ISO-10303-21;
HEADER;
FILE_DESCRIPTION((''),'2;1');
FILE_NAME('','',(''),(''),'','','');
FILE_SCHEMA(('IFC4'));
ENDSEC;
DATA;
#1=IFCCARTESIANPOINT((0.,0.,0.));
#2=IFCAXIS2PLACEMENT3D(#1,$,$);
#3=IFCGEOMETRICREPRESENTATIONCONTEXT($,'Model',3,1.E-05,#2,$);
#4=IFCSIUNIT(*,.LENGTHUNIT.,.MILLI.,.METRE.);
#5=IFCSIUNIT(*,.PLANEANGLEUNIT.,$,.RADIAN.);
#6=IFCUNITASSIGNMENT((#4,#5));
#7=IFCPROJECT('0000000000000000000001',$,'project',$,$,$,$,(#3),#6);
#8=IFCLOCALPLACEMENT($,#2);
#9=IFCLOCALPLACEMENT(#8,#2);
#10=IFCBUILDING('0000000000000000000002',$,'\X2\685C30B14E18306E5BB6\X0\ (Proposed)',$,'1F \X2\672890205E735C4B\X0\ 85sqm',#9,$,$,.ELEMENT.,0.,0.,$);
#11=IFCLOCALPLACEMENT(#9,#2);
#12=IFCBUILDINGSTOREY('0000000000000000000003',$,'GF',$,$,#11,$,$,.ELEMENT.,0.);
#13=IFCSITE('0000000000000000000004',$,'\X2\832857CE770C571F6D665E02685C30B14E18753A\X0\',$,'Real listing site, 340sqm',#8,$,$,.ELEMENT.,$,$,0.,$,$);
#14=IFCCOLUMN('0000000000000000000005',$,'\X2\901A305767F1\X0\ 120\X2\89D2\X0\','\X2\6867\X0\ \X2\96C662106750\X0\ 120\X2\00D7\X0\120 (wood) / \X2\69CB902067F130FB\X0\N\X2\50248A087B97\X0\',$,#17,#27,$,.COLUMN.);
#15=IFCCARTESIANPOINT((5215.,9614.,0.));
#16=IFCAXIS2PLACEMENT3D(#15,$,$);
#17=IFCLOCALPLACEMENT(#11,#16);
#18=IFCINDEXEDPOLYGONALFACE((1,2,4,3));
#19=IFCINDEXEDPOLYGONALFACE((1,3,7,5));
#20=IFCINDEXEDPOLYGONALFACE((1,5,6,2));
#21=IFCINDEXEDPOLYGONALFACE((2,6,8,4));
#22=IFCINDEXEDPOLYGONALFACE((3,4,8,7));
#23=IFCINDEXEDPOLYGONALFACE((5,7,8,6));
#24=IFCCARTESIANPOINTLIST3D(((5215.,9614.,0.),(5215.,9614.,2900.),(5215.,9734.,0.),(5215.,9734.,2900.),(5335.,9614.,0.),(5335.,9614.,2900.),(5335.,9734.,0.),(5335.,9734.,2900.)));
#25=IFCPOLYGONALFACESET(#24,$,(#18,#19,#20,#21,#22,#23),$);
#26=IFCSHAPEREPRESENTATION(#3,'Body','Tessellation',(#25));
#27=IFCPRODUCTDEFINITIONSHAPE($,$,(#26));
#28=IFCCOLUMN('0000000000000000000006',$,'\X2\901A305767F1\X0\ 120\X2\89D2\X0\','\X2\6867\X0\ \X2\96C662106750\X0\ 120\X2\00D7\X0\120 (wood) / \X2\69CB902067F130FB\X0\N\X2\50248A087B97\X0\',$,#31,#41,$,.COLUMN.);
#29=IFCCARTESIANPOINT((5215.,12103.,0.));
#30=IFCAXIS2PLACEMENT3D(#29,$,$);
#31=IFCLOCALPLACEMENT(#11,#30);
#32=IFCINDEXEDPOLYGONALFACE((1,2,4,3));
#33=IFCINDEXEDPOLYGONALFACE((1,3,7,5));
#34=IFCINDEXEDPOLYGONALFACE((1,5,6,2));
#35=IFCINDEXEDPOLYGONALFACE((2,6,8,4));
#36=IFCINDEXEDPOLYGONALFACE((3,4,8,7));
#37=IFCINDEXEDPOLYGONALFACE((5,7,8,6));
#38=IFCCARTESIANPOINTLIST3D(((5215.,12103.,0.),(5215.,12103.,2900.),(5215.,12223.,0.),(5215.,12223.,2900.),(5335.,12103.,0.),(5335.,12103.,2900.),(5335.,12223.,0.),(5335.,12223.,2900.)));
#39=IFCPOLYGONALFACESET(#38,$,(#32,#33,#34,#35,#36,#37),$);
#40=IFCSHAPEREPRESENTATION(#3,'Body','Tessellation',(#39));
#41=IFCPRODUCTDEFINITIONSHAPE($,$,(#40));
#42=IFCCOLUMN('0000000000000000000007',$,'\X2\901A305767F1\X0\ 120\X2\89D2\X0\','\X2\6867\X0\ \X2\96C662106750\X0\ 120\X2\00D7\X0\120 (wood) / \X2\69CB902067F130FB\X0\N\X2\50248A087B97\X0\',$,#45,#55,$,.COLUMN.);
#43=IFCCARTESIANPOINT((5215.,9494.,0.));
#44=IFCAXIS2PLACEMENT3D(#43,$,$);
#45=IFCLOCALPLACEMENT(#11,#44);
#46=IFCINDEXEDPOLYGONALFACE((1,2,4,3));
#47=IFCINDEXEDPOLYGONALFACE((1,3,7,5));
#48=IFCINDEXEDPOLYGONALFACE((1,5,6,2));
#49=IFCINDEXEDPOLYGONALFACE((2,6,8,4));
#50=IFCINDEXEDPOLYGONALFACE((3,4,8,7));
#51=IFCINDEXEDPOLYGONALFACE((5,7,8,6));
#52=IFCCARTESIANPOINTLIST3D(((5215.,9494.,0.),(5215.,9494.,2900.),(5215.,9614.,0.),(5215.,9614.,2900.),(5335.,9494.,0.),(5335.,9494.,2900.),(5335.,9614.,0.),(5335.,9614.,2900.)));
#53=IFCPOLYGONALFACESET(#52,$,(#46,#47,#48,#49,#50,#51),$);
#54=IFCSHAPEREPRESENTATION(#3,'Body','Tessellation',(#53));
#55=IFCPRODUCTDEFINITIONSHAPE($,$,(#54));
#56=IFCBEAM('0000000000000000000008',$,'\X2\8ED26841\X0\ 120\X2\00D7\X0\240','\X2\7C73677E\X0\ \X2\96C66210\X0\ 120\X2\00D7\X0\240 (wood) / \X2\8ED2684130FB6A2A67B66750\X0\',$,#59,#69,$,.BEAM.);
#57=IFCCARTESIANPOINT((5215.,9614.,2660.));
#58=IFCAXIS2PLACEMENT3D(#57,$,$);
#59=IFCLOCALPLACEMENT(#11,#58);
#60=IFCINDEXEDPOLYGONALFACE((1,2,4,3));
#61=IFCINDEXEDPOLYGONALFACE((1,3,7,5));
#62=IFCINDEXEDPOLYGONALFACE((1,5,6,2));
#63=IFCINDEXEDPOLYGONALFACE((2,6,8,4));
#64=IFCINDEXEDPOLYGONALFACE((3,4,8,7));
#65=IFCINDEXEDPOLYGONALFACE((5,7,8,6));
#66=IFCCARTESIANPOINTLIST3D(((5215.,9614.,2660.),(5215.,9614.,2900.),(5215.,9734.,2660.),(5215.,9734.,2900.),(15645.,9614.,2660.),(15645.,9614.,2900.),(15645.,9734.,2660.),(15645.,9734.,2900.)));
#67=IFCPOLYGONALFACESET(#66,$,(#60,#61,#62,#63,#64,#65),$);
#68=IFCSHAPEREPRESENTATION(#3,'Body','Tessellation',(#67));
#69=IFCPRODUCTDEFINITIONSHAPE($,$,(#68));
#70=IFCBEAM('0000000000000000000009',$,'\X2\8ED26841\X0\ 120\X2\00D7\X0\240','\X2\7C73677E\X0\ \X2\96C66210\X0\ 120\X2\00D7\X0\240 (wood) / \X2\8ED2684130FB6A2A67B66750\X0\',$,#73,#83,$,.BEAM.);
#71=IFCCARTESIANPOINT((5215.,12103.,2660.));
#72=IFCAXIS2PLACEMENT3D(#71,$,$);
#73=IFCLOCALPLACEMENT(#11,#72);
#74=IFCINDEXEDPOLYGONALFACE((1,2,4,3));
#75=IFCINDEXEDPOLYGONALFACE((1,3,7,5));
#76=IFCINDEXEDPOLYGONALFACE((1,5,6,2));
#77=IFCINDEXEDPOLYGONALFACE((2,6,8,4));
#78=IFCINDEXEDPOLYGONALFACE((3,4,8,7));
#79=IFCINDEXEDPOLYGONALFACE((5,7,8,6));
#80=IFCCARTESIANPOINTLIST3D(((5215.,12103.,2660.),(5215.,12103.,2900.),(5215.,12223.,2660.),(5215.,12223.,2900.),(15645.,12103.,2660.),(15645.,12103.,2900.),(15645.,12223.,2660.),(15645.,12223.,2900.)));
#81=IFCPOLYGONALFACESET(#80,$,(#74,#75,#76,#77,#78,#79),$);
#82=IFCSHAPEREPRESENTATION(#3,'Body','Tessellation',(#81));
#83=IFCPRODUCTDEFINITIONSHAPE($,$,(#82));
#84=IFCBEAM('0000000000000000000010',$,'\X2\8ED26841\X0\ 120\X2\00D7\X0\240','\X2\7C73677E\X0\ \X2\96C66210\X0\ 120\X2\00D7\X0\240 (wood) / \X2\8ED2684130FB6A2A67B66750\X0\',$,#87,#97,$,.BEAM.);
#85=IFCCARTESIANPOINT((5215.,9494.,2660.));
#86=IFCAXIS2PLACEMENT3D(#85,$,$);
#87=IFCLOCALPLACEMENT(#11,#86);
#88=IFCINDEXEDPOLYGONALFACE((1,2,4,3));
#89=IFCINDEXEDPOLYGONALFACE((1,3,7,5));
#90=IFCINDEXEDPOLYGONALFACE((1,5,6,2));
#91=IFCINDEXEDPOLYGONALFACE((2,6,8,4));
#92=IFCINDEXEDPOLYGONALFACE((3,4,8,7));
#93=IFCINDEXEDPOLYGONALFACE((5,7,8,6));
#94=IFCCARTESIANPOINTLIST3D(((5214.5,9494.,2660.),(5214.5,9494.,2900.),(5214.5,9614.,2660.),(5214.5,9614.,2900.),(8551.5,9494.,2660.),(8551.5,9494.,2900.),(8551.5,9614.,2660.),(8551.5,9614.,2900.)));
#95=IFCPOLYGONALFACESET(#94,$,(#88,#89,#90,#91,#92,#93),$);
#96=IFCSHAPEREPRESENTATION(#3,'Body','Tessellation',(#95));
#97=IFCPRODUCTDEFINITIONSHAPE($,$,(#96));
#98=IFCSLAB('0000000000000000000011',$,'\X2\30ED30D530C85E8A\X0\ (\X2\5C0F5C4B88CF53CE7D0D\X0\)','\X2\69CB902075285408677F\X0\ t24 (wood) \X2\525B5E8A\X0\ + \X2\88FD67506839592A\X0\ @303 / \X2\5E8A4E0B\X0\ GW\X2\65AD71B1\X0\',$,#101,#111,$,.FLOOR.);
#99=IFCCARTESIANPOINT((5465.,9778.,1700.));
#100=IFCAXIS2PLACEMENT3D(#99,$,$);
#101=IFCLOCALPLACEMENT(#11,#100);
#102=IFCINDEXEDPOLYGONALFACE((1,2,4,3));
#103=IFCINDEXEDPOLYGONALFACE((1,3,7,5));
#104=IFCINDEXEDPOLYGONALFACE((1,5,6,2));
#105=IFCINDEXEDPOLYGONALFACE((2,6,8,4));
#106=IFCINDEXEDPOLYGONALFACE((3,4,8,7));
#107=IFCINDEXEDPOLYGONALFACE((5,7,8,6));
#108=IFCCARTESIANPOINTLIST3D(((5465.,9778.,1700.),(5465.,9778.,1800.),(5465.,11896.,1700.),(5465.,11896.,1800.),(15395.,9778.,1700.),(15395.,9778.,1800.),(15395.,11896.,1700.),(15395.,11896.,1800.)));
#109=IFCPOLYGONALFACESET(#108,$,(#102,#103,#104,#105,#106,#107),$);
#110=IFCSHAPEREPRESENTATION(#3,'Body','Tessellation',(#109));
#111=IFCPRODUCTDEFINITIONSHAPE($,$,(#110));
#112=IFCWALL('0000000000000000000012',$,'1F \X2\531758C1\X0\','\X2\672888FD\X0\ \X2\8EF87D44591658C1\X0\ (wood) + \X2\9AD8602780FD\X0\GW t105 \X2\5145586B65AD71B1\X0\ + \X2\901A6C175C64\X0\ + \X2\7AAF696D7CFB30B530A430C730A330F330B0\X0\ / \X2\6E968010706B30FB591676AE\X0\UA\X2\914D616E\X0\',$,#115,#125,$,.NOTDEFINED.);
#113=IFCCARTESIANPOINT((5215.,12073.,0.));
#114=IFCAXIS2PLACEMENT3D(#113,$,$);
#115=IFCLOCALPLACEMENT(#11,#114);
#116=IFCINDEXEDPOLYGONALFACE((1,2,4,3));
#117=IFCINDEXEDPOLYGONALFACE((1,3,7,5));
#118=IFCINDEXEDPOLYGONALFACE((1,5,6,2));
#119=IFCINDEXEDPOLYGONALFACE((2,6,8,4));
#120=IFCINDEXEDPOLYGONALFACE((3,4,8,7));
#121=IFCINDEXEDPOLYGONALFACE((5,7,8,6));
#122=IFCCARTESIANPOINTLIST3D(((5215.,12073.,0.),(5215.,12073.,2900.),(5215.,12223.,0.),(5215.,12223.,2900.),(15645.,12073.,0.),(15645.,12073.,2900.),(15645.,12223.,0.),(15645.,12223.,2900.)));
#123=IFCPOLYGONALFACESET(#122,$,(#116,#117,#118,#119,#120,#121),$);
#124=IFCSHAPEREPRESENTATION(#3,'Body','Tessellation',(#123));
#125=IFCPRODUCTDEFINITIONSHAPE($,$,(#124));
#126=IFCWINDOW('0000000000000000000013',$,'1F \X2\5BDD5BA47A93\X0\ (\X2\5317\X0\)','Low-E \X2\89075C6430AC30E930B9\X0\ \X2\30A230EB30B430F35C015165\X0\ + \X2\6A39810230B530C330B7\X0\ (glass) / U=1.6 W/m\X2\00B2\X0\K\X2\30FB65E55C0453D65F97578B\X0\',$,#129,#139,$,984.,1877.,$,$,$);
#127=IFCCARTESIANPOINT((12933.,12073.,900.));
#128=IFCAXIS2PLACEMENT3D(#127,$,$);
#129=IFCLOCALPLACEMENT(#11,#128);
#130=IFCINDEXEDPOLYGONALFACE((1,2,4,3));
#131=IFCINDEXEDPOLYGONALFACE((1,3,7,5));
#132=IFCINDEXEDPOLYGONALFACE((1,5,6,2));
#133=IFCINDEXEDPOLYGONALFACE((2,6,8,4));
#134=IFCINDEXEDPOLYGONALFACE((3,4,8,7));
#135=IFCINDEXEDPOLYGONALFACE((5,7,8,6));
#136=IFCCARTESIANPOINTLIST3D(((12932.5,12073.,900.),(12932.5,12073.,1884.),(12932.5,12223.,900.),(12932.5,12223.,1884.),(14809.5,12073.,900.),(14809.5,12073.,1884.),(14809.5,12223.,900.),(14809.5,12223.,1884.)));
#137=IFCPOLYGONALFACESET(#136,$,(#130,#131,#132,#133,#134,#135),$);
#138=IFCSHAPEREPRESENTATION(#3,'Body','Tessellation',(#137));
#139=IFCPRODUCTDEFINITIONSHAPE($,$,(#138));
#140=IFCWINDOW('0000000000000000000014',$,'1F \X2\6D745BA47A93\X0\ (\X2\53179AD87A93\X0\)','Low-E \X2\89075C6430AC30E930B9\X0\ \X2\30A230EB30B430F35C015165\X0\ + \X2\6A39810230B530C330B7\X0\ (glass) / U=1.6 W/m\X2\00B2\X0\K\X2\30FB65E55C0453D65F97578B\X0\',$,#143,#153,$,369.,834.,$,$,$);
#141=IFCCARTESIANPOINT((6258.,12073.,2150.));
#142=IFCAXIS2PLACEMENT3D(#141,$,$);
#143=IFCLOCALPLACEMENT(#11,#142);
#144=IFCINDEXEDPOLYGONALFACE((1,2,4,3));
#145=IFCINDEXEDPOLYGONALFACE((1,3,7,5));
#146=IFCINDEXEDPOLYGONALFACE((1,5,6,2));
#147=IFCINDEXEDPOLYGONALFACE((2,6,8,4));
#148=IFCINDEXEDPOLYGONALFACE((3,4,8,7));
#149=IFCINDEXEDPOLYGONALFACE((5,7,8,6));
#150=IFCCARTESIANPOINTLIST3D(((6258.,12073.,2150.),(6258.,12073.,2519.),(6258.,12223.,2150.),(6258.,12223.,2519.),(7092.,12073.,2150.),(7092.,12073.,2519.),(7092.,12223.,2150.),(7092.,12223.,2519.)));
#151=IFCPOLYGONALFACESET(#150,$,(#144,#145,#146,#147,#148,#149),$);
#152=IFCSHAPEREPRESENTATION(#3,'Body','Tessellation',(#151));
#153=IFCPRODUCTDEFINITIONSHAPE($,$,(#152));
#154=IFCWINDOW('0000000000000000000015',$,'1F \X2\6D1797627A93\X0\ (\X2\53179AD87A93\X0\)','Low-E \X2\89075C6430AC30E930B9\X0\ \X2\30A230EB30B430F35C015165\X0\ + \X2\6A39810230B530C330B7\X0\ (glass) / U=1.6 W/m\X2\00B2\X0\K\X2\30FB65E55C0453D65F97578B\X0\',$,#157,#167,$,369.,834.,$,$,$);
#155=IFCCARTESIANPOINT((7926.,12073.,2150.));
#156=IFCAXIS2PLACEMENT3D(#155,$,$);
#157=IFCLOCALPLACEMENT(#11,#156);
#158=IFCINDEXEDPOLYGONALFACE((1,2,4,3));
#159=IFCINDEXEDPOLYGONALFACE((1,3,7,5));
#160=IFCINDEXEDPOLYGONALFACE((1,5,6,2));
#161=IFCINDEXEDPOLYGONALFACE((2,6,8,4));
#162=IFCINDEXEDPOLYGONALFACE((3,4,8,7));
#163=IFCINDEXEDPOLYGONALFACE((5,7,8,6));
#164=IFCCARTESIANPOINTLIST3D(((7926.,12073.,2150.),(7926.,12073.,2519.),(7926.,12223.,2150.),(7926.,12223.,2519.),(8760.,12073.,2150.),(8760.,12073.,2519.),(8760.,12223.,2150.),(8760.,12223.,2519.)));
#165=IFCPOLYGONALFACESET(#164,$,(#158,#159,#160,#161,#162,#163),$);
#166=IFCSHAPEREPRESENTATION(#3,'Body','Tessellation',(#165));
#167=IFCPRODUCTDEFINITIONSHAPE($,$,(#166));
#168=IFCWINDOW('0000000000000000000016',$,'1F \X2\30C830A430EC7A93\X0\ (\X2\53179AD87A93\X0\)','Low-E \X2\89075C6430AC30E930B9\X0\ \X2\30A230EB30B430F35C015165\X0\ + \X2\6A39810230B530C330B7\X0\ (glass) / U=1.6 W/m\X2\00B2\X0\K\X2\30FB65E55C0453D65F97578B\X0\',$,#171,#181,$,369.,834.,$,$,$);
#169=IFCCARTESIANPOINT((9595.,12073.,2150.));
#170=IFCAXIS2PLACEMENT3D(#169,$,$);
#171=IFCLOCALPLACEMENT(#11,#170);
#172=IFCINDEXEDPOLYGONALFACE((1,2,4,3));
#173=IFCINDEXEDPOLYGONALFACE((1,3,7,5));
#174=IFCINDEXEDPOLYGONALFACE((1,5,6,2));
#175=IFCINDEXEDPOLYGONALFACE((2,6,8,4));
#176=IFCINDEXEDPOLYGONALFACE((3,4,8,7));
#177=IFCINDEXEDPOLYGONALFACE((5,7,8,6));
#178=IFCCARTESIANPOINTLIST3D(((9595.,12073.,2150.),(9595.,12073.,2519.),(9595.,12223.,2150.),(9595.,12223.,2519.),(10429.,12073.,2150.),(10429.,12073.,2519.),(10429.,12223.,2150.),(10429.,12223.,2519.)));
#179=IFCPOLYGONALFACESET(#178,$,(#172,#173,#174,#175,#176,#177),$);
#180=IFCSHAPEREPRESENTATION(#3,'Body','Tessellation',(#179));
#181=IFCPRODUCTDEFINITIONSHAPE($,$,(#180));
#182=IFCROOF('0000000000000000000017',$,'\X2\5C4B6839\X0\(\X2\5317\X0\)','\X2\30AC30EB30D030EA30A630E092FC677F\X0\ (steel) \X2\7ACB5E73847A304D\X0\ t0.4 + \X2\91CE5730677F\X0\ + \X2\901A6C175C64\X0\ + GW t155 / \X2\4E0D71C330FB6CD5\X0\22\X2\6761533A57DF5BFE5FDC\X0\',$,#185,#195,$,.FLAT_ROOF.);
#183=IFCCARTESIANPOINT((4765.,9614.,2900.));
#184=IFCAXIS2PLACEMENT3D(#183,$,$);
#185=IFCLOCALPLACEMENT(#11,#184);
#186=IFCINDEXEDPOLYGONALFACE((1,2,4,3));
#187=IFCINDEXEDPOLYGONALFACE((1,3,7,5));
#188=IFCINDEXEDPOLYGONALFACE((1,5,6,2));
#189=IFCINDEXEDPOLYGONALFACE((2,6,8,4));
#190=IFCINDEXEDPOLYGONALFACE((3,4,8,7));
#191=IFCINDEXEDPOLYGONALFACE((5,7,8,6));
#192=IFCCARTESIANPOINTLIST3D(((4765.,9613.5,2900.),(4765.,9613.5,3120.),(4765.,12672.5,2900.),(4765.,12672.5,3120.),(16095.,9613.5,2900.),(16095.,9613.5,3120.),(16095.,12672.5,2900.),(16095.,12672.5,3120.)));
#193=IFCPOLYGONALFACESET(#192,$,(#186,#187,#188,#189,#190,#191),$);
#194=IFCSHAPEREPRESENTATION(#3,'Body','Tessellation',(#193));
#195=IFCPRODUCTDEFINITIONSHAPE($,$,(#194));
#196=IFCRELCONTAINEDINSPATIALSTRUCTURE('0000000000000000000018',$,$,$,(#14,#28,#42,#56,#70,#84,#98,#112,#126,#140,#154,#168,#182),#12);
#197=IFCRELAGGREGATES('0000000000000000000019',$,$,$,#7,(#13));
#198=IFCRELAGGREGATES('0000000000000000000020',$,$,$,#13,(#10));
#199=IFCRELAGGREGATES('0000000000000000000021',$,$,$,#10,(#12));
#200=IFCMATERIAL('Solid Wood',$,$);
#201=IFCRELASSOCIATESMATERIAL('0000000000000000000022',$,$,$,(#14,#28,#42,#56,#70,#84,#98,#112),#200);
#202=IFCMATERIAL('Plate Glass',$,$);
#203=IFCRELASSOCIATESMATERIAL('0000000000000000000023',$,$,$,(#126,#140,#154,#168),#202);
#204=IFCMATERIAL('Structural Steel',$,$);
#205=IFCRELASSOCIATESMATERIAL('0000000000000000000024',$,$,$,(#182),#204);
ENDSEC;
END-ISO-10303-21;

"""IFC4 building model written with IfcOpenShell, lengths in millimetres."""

from ifc_helpers import new_model, si_unit, frame, frame_2d, origin, place, context, project, spatial, rectangle, extrude, material, element, fill, save


model = new_model("IFC4")

# Units and contexts
model_context = context("Model", 3, precision=1e-05, world=origin())
ifc_project = project(units=[si_unit("LENGTHUNIT", "METRE", prefix="MILLI"), si_unit("PLANEANGLEUNIT", "RADIAN")], contexts=[model_context])

# Site, building, storey
site_placement = place(None, origin())
site = spatial("IfcSite", under=ifc_project, at=site_placement, Name="茨城県土浦市桜ケ丘町", ObjectType="Real listing site, 340sqm", CompositionType="ELEMENT", RefElevation=0.0)
building_placement = place(site_placement, origin())
building = spatial("IfcBuilding", under=site, at=building_placement, Name="桜ケ丘の家 (Proposed)", ObjectType="1F 木造平屋 85sqm", CompositionType="ELEMENT", ElevationOfRefHeight=0.0, ElevationOfTerrain=0.0)
storey_placement = place(building_placement, origin())
storey = spatial("IfcBuildingStorey", under=building, at=storey_placement, Name="GF", CompositionType="ELEMENT", Elevation=0.0)

# Columns
ifc_material_1 = material(Name="Solid Wood")
column_1_placement = place(storey_placement, frame((5215.0, 9614.0, 0.0)))
element("IfcColumn", 1, at=column_1_placement, inside=storey, material=ifc_material_1, Name="通し柱 120角", Description="桧 集成材 120×120 (wood) / 構造柱・N値計算", PredefinedType="COLUMN", context=model_context, shape_type="SweptSolid", body=[
    extrude(rectangle(XDim=120.0, YDim=120.0, at=frame_2d((60.0, 60.0))), frame((5215.0, 9614.0, 0.0)), (0.0, 0.0, 1.0), 2900.0),
])
column_2_placement = place(storey_placement, frame((5215.0, 12103.0, 0.0)))
element("IfcColumn", 2, at=column_2_placement, inside=storey, material=ifc_material_1, Name="通し柱 120角", Description="桧 集成材 120×120 (wood) / 構造柱・N値計算", PredefinedType="COLUMN", context=model_context, shape_type="SweptSolid", body=[
    extrude(rectangle(XDim=120.0, YDim=120.0, at=frame_2d((60.0, 60.0))), frame((5215.0, 12103.0, 0.0)), (0.0, 0.0, 1.0), 2900.0),
])
column_3_placement = place(storey_placement, frame((5215.0, 9494.0, 0.0)))
element("IfcColumn", 3, at=column_3_placement, inside=storey, material=ifc_material_1, Name="通し柱 120角", Description="桧 集成材 120×120 (wood) / 構造柱・N値計算", PredefinedType="COLUMN", context=model_context, shape_type="SweptSolid", body=[
    extrude(rectangle(XDim=120.0, YDim=120.0, at=frame_2d((60.0, 60.0))), frame((5215.0, 9494.0, 0.0)), (0.0, 0.0, 1.0), 2900.0),
])

# Beams
beam_1_placement = place(storey_placement, frame((5215.0, 9614.0, 2660.0)))
element("IfcBeam", 4, at=beam_1_placement, inside=storey, material=ifc_material_1, Name="軒桁 120×240", Description="米松 集成 120×240 (wood) / 軒桁・横架材", PredefinedType="BEAM", context=model_context, shape_type="SweptSolid", body=[
    extrude(rectangle(XDim=10430.0, YDim=120.0, at=frame_2d((5215.0, 60.0))), frame((5215.0, 9614.0, 2660.0)), (0.0, 0.0, 1.0), 240.0),
])
beam_2_placement = place(storey_placement, frame((5215.0, 12103.0, 2660.0)))
element("IfcBeam", 5, at=beam_2_placement, inside=storey, material=ifc_material_1, Name="軒桁 120×240", Description="米松 集成 120×240 (wood) / 軒桁・横架材", PredefinedType="BEAM", context=model_context, shape_type="SweptSolid", body=[
    extrude(rectangle(XDim=10430.0, YDim=120.0, at=frame_2d((5215.0, 60.0))), frame((5215.0, 12103.0, 2660.0)), (0.0, 0.0, 1.0), 240.0),
])
beam_3_placement = place(storey_placement, frame((5215.0, 9494.0, 2660.0)))
element("IfcBeam", 6, at=beam_3_placement, inside=storey, material=ifc_material_1, Name="軒桁 120×240", Description="米松 集成 120×240 (wood) / 軒桁・横架材", PredefinedType="BEAM", context=model_context, shape_type="SweptSolid", body=[
    extrude(rectangle(XDim=3337.0, YDim=120.0, at=frame_2d((1668.0, 60.0))), frame((5215.0, 9494.0, 2660.0)), (0.0, 0.0, 1.0), 240.0),
])

# Slab
slab_1_placement = place(storey_placement, frame((5465.0, 9778.0, 1700.0)))
element("IfcSlab", 7, at=slab_1_placement, inside=storey, material=ifc_material_1, Name="ロフト床 (小屋裏収納)", Description="構造用合板 t24 (wood) 剛床 + 製材根太 @303 / 床下 GW断熱", PredefinedType="FLOOR", context=model_context, shape_type="SweptSolid", body=[
    extrude(rectangle(XDim=9930.0, YDim=2118.0, at=frame_2d((4965.0, 1059.0))), frame((5465.0, 9778.0, 1700.0)), (0.0, 0.0, 1.0), 100.0),
])

# Wall, openings, windows
wall_1_placement = place(storey_placement, frame((5215.0, 12073.0, 0.0)))
wall_1 = element("IfcWall", 8, at=wall_1_placement, inside=storey, material=ifc_material_1, Name="1F 北壁", Description="木製 軸組外壁 (wood) + 高性能GW t105 充填断熱 + 通気層 + 窯業系サイディング / 準耐火・外皮UA配慮", PredefinedType="NOTDEFINED", context=model_context, shape_type="SweptSolid", body=[
    extrude(rectangle(XDim=10430.0, YDim=150.0, at=frame_2d((5215.0, 75.0))), frame((5215.0, 12073.0, 0.0)), (0.0, 0.0, 1.0), 2900.0),
])
opening_1_placement = place(storey_placement, frame((12933.0, 12073.0, 900.0)))
opening_1 = element("IfcOpeningElement", 9, at=opening_1_placement, cuts=wall_1, PredefinedType="NOTDEFINED", context=model_context, shape_type="SweptSolid", body=[
    extrude(rectangle(XDim=1877.0, YDim=150.0, at=frame_2d((938.0, 75.0))), frame((12933.0, 12073.0, 900.0)), (0.0, 0.0, 1.0), 984.0),
])
opening_2_placement = place(storey_placement, frame((6258.0, 12073.0, 2150.0)))
opening_2 = element("IfcOpeningElement", 10, at=opening_2_placement, cuts=wall_1, PredefinedType="NOTDEFINED", context=model_context, shape_type="SweptSolid", body=[
    extrude(rectangle(XDim=834.0, YDim=150.0, at=frame_2d((417.0, 75.0))), frame((6258.0, 12073.0, 2150.0)), (0.0, 0.0, 1.0), 369.0),
])
opening_3_placement = place(storey_placement, frame((7926.0, 12073.0, 2150.0)))
opening_3 = element("IfcOpeningElement", 11, at=opening_3_placement, cuts=wall_1, PredefinedType="NOTDEFINED", context=model_context, shape_type="SweptSolid", body=[
    extrude(rectangle(XDim=834.0, YDim=150.0, at=frame_2d((417.0, 75.0))), frame((7926.0, 12073.0, 2150.0)), (0.0, 0.0, 1.0), 369.0),
])
opening_4_placement = place(storey_placement, frame((9595.0, 12073.0, 2150.0)))
opening_4 = element("IfcOpeningElement", 12, at=opening_4_placement, cuts=wall_1, PredefinedType="NOTDEFINED", context=model_context, shape_type="SweptSolid", body=[
    extrude(rectangle(XDim=834.0, YDim=150.0, at=frame_2d((417.0, 75.0))), frame((9595.0, 12073.0, 2150.0)), (0.0, 0.0, 1.0), 369.0),
])
ifc_material_2 = material(Name="Plate Glass")
window_1_placement = place(storey_placement, frame((12933.0, 12073.0, 900.0)))
window_1 = element("IfcWindow", 13, at=window_1_placement, inside=storey, material=ifc_material_2, Name="1F 寝室窓 (北)", Description="Low-E 複層ガラス アルゴン封入 + 樹脂サッシ (glass) / U=1.6 W/m²K・日射取得型", OverallHeight=984.0, OverallWidth=1877.0, context=model_context, shape_type="SweptSolid", body=[
    extrude(rectangle(XDim=1877.0, YDim=150.0, at=frame_2d((938.0, 75.0))), frame((12933.0, 12073.0, 900.0)), (0.0, 0.0, 1.0), 984.0),
])
fill(opening_1, window_1)
window_2_placement = place(storey_placement, frame((6258.0, 12073.0, 2150.0)))
window_2 = element("IfcWindow", 14, at=window_2_placement, inside=storey, material=ifc_material_2, Name="1F 浴室窓 (北高窓)", Description="Low-E 複層ガラス アルゴン封入 + 樹脂サッシ (glass) / U=1.6 W/m²K・日射取得型", OverallHeight=369.0, OverallWidth=834.0, context=model_context, shape_type="SweptSolid", body=[
    extrude(rectangle(XDim=834.0, YDim=150.0, at=frame_2d((417.0, 75.0))), frame((6258.0, 12073.0, 2150.0)), (0.0, 0.0, 1.0), 369.0),
])
fill(opening_2, window_2)
window_3_placement = place(storey_placement, frame((7926.0, 12073.0, 2150.0)))
window_3 = element("IfcWindow", 15, at=window_3_placement, inside=storey, material=ifc_material_2, Name="1F 洗面窓 (北高窓)", Description="Low-E 複層ガラス アルゴン封入 + 樹脂サッシ (glass) / U=1.6 W/m²K・日射取得型", OverallHeight=369.0, OverallWidth=834.0, context=model_context, shape_type="SweptSolid", body=[
    extrude(rectangle(XDim=834.0, YDim=150.0, at=frame_2d((417.0, 75.0))), frame((7926.0, 12073.0, 2150.0)), (0.0, 0.0, 1.0), 369.0),
])
fill(opening_3, window_3)
window_4_placement = place(storey_placement, frame((9595.0, 12073.0, 2150.0)))
window_4 = element("IfcWindow", 16, at=window_4_placement, inside=storey, material=ifc_material_2, Name="1F トイレ窓 (北高窓)", Description="Low-E 複層ガラス アルゴン封入 + 樹脂サッシ (glass) / U=1.6 W/m²K・日射取得型", OverallHeight=369.0, OverallWidth=834.0, context=model_context, shape_type="SweptSolid", body=[
    extrude(rectangle(XDim=834.0, YDim=150.0, at=frame_2d((417.0, 75.0))), frame((9595.0, 12073.0, 2150.0)), (0.0, 0.0, 1.0), 369.0),
])
fill(opening_4, window_4)

# Roof
ifc_material_3 = material(Name="Structural Steel")
roof_placement = place(storey_placement, frame((4765.0, 9614.0, 2900.0)))
element("IfcRoof", 17, at=roof_placement, inside=storey, material=ifc_material_3, Name="屋根(北)", Description="ガルバリウム鋼板 (steel) 立平葺き t0.4 + 野地板 + 通気層 + GW t155 / 不燃・法22条区域対応", PredefinedType="FLAT_ROOF", context=model_context, shape_type="SweptSolid", body=[
    extrude(rectangle(XDim=11330.0, YDim=3059.0, at=frame_2d((5665.0, 1529.0))), frame((4765.0, 9614.0, 2900.0)), (0.0, 0.0, 1.0), 220.0),
])

save(model, "model.ifc")
